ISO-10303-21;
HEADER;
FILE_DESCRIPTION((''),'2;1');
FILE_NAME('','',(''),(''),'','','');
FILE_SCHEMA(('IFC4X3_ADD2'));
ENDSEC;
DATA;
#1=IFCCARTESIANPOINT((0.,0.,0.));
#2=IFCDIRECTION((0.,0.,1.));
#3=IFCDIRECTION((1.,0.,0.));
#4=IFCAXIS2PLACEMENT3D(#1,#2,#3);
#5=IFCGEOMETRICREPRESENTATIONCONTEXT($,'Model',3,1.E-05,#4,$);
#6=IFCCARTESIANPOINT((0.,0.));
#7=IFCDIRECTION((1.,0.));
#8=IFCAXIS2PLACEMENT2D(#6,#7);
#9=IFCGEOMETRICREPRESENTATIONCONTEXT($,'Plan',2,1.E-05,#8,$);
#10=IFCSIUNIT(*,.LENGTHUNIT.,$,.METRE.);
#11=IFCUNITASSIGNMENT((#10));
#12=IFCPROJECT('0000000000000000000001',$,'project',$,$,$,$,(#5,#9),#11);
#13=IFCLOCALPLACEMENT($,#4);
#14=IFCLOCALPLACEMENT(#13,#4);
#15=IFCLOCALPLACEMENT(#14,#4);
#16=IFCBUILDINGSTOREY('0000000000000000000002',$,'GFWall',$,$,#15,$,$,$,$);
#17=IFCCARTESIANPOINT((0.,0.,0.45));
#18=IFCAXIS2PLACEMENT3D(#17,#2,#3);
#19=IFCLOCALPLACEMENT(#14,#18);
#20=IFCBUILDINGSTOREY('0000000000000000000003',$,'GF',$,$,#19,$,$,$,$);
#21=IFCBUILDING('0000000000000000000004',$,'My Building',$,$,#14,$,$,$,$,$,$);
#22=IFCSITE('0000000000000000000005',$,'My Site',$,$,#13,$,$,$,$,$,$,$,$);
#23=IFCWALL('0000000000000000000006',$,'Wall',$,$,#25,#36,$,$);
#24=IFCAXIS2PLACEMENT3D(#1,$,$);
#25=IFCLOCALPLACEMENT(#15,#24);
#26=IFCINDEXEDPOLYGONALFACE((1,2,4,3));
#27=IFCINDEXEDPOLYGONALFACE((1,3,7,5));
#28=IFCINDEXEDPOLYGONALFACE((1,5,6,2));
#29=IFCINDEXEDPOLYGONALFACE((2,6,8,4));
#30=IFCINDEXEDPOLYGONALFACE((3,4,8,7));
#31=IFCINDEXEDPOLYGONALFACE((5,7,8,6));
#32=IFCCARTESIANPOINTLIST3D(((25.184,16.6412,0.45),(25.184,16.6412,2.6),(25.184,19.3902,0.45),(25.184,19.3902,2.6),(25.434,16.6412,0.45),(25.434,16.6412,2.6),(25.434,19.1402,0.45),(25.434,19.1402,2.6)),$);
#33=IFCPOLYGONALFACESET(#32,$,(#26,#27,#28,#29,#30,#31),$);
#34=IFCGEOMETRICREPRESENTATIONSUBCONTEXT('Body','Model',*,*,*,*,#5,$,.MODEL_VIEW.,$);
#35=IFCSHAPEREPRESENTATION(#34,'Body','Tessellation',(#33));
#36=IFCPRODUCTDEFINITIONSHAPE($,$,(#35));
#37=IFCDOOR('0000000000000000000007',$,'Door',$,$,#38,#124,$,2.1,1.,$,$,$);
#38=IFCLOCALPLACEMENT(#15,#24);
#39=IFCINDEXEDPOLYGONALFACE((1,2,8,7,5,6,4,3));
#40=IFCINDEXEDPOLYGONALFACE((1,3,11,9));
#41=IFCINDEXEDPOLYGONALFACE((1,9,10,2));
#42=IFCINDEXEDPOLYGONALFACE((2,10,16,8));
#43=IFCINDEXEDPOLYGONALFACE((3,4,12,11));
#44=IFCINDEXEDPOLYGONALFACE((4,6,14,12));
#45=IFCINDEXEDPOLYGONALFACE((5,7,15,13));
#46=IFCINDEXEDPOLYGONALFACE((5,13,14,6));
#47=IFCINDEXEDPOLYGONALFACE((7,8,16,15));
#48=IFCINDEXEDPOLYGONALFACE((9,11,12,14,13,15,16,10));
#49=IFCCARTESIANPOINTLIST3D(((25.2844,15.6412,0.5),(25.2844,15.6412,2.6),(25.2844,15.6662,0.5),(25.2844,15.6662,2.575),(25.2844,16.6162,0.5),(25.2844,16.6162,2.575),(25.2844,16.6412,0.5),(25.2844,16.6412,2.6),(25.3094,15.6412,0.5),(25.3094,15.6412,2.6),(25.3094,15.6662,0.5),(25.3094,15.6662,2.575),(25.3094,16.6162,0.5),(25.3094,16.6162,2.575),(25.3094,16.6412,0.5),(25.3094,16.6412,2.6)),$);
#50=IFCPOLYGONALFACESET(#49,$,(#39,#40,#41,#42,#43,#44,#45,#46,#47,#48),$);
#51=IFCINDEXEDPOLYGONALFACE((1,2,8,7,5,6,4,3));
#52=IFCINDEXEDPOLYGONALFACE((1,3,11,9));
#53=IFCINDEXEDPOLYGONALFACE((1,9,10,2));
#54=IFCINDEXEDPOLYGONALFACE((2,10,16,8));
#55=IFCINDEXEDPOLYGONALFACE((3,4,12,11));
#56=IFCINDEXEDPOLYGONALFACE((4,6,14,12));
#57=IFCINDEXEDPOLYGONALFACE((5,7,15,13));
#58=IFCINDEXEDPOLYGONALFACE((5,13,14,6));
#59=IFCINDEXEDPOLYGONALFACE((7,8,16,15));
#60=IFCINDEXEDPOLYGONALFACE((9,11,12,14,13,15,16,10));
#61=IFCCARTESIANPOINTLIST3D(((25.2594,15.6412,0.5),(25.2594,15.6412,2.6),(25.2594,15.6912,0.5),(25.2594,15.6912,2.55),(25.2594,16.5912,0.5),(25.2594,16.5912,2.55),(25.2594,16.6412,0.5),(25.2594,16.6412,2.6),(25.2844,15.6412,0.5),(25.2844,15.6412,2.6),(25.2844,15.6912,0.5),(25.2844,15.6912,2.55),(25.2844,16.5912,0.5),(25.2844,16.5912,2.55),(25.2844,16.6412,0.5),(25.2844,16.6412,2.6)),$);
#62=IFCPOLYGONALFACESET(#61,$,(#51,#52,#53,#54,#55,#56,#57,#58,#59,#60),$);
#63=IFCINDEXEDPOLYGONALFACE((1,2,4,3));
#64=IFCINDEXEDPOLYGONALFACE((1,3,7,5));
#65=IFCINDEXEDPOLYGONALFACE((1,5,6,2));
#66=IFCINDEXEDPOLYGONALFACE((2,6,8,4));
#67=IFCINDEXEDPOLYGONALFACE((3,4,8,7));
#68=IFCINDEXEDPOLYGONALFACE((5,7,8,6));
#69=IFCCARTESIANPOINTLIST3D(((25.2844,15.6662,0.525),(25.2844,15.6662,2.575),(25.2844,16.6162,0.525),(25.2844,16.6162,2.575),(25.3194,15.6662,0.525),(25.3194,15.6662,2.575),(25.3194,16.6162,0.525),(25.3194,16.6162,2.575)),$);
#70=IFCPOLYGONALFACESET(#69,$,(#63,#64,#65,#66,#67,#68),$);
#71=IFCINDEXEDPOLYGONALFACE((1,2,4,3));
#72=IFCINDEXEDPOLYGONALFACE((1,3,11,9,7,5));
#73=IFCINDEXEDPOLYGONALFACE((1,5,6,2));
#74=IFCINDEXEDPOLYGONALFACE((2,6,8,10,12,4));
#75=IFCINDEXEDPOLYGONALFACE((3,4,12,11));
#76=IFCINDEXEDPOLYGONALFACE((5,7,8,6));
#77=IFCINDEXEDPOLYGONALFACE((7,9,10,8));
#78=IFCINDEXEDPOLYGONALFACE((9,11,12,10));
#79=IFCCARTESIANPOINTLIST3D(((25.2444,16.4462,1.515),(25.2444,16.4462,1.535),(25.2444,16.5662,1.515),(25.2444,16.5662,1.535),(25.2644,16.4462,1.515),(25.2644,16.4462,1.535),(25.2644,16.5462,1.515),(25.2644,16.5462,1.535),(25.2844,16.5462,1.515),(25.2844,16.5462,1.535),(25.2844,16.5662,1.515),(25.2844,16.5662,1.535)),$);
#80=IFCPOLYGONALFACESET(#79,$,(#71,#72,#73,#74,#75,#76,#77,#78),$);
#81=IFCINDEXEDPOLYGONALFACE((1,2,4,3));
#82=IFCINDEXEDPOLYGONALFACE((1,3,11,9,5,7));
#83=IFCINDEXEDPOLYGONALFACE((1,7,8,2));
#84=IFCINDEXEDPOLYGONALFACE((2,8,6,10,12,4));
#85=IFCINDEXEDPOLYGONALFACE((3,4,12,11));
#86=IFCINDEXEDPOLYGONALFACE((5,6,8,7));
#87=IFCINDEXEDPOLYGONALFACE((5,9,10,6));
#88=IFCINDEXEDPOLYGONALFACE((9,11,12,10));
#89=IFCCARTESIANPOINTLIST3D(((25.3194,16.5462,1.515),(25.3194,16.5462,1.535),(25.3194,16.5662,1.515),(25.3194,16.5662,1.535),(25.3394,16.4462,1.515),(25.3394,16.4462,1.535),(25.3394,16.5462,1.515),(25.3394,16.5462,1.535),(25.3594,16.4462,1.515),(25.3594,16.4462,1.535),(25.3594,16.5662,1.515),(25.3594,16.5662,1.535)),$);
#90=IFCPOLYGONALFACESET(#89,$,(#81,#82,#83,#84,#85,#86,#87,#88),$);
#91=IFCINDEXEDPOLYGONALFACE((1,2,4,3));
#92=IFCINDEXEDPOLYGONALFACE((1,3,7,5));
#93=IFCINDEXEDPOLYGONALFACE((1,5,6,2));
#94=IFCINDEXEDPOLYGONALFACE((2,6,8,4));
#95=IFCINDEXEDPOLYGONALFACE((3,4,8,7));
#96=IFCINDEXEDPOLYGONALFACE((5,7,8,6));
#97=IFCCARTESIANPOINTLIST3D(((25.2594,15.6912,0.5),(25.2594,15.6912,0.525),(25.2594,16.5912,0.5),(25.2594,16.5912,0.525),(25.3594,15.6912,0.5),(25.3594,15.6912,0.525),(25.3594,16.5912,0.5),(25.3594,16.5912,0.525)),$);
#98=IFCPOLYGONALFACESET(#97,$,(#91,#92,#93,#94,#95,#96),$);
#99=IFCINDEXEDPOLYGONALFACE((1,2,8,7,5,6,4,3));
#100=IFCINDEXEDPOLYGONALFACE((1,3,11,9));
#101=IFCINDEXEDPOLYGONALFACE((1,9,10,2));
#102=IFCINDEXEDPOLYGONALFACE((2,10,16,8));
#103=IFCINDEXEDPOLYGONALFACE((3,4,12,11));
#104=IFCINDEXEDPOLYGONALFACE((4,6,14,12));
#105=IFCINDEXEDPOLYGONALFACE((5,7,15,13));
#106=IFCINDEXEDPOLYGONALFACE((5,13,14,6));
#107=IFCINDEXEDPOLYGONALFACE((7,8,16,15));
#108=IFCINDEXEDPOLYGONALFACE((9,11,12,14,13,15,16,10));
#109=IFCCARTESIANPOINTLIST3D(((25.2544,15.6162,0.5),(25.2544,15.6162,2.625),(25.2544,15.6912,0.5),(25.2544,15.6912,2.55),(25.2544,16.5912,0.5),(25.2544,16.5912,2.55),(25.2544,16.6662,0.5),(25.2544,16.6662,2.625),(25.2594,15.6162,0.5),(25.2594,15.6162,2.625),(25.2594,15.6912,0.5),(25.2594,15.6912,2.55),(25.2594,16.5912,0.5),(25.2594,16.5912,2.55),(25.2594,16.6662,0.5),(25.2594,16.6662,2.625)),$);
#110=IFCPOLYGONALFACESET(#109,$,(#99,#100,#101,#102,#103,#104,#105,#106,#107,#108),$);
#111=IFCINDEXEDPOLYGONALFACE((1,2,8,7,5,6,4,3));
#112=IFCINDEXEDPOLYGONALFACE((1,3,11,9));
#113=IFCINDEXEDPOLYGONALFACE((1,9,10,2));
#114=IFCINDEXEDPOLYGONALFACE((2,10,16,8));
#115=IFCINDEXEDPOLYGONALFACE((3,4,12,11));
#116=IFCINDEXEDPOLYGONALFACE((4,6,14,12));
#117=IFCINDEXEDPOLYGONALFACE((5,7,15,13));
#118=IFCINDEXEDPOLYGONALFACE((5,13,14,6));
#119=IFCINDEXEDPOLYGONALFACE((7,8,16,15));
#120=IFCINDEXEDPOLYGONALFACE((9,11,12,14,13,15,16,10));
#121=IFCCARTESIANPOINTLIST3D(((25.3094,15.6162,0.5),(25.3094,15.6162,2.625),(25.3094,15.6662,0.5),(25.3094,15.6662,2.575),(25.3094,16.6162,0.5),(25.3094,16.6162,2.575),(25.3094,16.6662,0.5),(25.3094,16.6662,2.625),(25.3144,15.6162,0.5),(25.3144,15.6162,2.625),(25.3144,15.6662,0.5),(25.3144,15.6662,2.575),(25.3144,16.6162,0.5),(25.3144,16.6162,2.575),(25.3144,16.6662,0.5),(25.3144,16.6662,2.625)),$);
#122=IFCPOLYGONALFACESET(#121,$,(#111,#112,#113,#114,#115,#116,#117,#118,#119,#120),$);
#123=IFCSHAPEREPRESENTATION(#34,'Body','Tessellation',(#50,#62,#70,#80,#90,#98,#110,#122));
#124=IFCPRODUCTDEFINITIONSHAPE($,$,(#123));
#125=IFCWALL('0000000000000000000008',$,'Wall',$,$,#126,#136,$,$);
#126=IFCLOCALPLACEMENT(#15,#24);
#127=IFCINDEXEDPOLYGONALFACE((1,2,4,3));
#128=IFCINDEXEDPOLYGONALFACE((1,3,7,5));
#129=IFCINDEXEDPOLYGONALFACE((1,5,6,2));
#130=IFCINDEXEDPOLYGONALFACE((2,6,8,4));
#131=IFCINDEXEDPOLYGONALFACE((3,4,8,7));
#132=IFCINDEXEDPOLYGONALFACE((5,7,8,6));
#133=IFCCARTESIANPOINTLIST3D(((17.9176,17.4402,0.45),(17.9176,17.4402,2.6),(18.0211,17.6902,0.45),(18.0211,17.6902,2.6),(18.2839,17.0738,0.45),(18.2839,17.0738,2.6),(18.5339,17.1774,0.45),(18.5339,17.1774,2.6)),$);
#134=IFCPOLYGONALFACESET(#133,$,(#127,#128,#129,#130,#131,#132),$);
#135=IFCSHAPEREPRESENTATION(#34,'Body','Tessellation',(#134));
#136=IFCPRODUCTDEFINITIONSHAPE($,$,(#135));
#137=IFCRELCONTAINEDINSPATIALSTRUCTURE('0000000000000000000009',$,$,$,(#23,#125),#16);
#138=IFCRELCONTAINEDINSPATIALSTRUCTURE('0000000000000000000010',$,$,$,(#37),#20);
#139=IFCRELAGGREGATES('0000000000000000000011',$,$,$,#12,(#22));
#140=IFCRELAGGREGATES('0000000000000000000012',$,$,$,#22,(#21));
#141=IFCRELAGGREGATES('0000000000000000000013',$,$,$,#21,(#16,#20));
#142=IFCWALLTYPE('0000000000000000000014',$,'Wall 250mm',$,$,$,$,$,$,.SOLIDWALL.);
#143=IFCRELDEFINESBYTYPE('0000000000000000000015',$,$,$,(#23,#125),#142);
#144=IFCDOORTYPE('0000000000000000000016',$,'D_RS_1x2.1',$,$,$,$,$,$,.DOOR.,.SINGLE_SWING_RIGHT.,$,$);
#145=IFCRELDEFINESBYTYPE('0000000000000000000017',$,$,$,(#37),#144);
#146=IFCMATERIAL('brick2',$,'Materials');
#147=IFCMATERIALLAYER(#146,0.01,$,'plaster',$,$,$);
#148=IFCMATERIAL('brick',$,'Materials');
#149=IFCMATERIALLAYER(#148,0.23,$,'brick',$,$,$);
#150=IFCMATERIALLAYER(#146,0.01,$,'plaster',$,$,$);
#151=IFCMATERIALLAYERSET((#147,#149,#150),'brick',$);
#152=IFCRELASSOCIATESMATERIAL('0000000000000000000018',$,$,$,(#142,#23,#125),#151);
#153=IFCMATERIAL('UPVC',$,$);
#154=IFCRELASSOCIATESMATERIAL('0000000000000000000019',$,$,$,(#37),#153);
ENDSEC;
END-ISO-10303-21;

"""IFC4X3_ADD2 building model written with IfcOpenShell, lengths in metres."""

from ifc_helpers import new_model, entity, si_unit, frame, origin_with_axes, origin_2d_with_axis, place, context, subcontext, project, spatial, line, indexed_curve, outline, extrude, shape, source, transform, mapped, material, layer, layer_set, layer_usage, type_object, type_shapes, element, fill, save


model = new_model("IFC4X3_ADD2")

# Units and contexts
model_context = context("Model", 3, precision=1e-05, world=origin_with_axes())
plan_context = context("Plan", 2, precision=1e-05, world=origin_2d_with_axis())
body_context_1 = subcontext(model_context, "Body", "Model", "MODEL_VIEW")
body_context_2 = subcontext(plan_context, "Body", "Plan", "PLAN_VIEW")
ifc_project = project(units=[si_unit("LENGTHUNIT", "METRE")], contexts=[model_context, plan_context])

# Site, building, storey
site_placement = place(None, origin_with_axes())
site = spatial("IfcSite", under=ifc_project, at=site_placement, Name="My Site")
building_placement = place(site_placement, origin_with_axes())
building = spatial("IfcBuilding", under=site, at=building_placement, Name="My Building")
storey_1_placement = place(building_placement, origin_with_axes())
storey_1 = spatial("IfcBuildingStorey", under=building, at=storey_1_placement, Name="GFWall")

# Shared definitions
ifc_material_1 = material(Name="brick2", Category="Materials")
ifc_layer_1 = layer(ifc_material_1, 0.01, Name="plaster")
ifc_material_2 = material(Name="brick", Category="Materials")
ifc_layer_2 = layer(ifc_material_2, 0.23, Name="brick")
ifc_layer_3 = layer(ifc_material_1, 0.01, Name="plaster")
ifc_layer_set_1 = layer_set([ifc_layer_1, ifc_layer_2, ifc_layer_3], Name="brick")
wall_type_1 = type_object("IfcWallType", Name="Wall 250mm", PredefinedType="SOLIDWALL", material=ifc_layer_set_1)

# Shared definitions
storey_2_placement = place(building_placement, frame((0.0, 0.0, 0.45), z_axis=(0.0, 0.0, 1.0), x_axis=(1.0, 0.0, 0.0)))
storey_2 = spatial("IfcBuildingStorey", under=building, at=storey_2_placement, Name="GF")

# Shared definitions
ifc_material_3 = material(Name="UPVC")

# Wall, opening, door
ifc_layer_usage_1 = layer_usage(ifc_layer_set_1, "AXIS2", "POSITIVE", 0.0)
wall_1_placement = place(storey_1_placement, frame((25.434, 15.6412, 0.45), z_axis=(0.0, 0.0, 1.0), x_axis=(0.000001, 1.0, 0.0)))
wall_1 = element("IfcWall", 1, at=wall_1_placement, inside=storey_1, type_object=wall_type_1, material=ifc_layer_usage_1, Name="Wall", context=body_context_1, shape_type="SweptSolid", body=[
    extrude(outline(indexed_curve([(0.0, 0.0), (0.0, 0.25), (3.749, 0.25), (3.499, 0.0)], segments=[line(1, 2, 3, 4, 1)])), origin_with_axes(), (0.0, 0.0, 1.0), 2.15),
])
shared_shape_1 = source(origin_with_axes(), body_context_1, "Body", "SweptSolid", [
    extrude(outline(indexed_curve([(0.0, 2.1), (1.0, 2.1), (1.0, -0.05), (0.0, -0.05), (0.0, 2.1)])), frame((0.0, -0.6, 0.0), z_axis=(0.0, -1.0, 0.0), x_axis=(1.0, 0.0, 0.0)), (0.0, 0.0, -1.0), 1.2),
])
opening_1_placement = place(wall_1_placement, frame((1.0, 0.1746, 0.05), z_axis=(0.0, 0.0, 1.0), x_axis=(-1.0, 0.0, 0.0)))
opening_1 = element("IfcOpeningElement", 2, at=opening_1_placement, cuts=wall_1, PredefinedType="OPENING", context=body_context_1, shape_type="MappedRepresentation", body=[
    mapped(shared_shape_1, transform((0.0, 0.0, 0.0), x_axis=(1.0, 0.0, 0.0), y_axis=(0.0, 1.0, 0.0), z_axis=(0.0, 0.0, 1.0), scale=1.0)),
])
door_type_1 = type_object("IfcDoorType", Name="D_RS_1x2.1", OperationType="SINGLE_SWING_RIGHT", PredefinedType="DOOR")
shared_shape_2 = source(origin_with_axes(), body_context_1, "Body", "SweptSolid", [
    extrude(outline(indexed_curve([(0.0, 0.0), (0.0, 2.1), (1.0, 2.1), (1.0, 0.0), (0.975, 0.0), (0.975, 2.075), (0.025, 2.075), (0.025, 0.0)], segments=[line(1, 2, 3, 4, 5, 6, 7, 8, 1)])), frame((0.0, 0.025, 0.0), z_axis=(0.0, -1.0, 0.0), x_axis=(1.0, 0.0, 0.0)), (0.0, 0.0, -1.0), 0.025),
    extrude(outline(indexed_curve([(0.0, 0.0), (0.0, 2.1), (1.0, 2.1), (1.0, 0.0), (0.95, 0.0), (0.95, 2.05), (0.05, 2.05), (0.05, 0.0)], segments=[line(1, 2, 3, 4, 5, 6, 7, 8, 1)])), frame((0.0, 0.0, 0.0), z_axis=(0.0, -1.0, 0.0), x_axis=(1.0, 0.0, 0.0)), (0.0, 0.0, -1.0), 0.025),
    extrude(outline(indexed_curve([(0.0, 0.0), (0.95, 0.0), (0.95, 0.035), (0.0, 0.035)], segments=[line(1, 2, 3, 4, 1)])), frame((0.025, 0.025, 0.025), z_axis=(0.0, 0.0, 1.0), x_axis=(1.0, 0.0, 0.0)), (0.0, 0.0, 1.0), 2.05),
    extrude(outline(indexed_curve([(0.0, 0.0), (0.0, -0.04), (0.12, -0.04), (0.12, -0.02), (0.02, -0.02), (0.02, 0.0)], segments=[line(1, 2, 3, 4, 5, 6, 1)])), frame((0.075, 0.025, 1.015), z_axis=(0.0, 0.0, 1.0), x_axis=(1.0, 0.0, 0.0)), (0.0, 0.0, 1.0), 0.02),
    extrude(outline(indexed_curve([(0.0, 0.0), (0.0, 0.04), (0.12, 0.04), (0.12, 0.02), (0.02, 0.02), (0.02, 0.0)], segments=[line(1, 2, 3, 4, 5, 6, 1)])), frame((0.075, 0.06, 1.015), z_axis=(0.0, 0.0, 1.0), x_axis=(1.0, 0.0, 0.0)), (0.0, 0.0, 1.0), 0.02),
    extrude(outline(indexed_curve([(0.0, 0.0), (0.9, 0.0), (0.9, 0.1), (0.0, 0.1)], segments=[line(1, 2, 3, 4, 1)])), frame((0.05, 0.0, 0.0), z_axis=(0.0, 0.0, 1.0), x_axis=(1.0, 0.0, 0.0)), (0.0, 0.0, 1.0), 0.025),
    extrude(outline(indexed_curve([(0.0, 0.0), (0.0, 2.125), (1.05, 2.125), (1.05, 0.0), (0.975, 0.0), (0.975, 2.05), (0.075, 2.05), (0.075, 0.0)], segments=[line(1, 2, 3, 4, 5, 6, 7, 8, 1)])), frame((-0.025, -0.005, 0.0), z_axis=(0.0, -1.0, 0.0), x_axis=(1.0, 0.0, 0.0)), (0.0, 0.0, -1.0), 0.005),
    extrude(outline(indexed_curve([(0.0, 0.0), (0.0, 2.125), (1.05, 2.125), (1.05, 0.0), (1.0, 0.0), (1.0, 2.075), (0.05, 2.075), (0.05, 0.0)], segments=[line(1, 2, 3, 4, 5, 6, 7, 8, 1)])), frame((-0.025, 0.05, 0.0), z_axis=(0.0, -1.0, 0.0), x_axis=(1.0, 0.0, 0.0)), (0.0, 0.0, -1.0), 0.005),
])
shared_shape_3 = source(origin_with_axes(), body_context_2, "Body", "Curve2D", [
    entity("IfcIndexedPolyCurve", entity("IfcCartesianPointList2D", [[0.0, 0.0], [0.0, 0.05], [0.025, 0.05], [0.025, 0.025], [0.05, 0.025], [0.05, 0.0]]), [entity("IfcLineIndex", [1, 2, 3, 4, 5, 6, 1])]),
    entity("IfcIndexedPolyCurve", entity("IfcCartesianPointList2D", [[1.0, 0.0], [1.0, 0.05], [0.975, 0.05], [0.975, 0.025], [0.95, 0.025], [0.95, 0.0]]), [entity("IfcLineIndex", [1, 2, 3, 4, 5, 6, 1])]),
    entity("IfcTrimmedCurve", entity("IfcEllipse", entity("IfcAxis2Placement2D", entity("IfcCartesianPoint", [0.94, 0.05]), entity("IfcDirection", [1.0, 0.0])), 0.915, 0.95), [entity("IfcCartesianPoint", [0.94, 1.0])], [entity("IfcCartesianPoint", [0.025, 0.05])], True, "CARTESIAN"),
    entity("IfcIndexedPolyCurve", entity("IfcCartesianPointList2D", [[0.975, 0.05], [0.94, 0.05], [0.94, 1.0], [0.975, 1.0]]), [entity("IfcLineIndex", [1, 2, 3, 4, 1])]),
])
type_shapes(door_type_1, [shared_shape_2, shared_shape_3])
door_1_placement = place(opening_1_placement, origin_with_axes())
door_1 = element("IfcDoor", 3, at=door_1_placement, inside=storey_2, type_object=door_type_1, material=ifc_material_3, Name="Door", OverallHeight=2.1, OverallWidth=1.0, shapes=[
    shape(body_context_1, "Body", "MappedRepresentation", [mapped(shared_shape_2, transform((0.0, 0.0, 0.0), x_axis=(1.0, 0.0, 0.0), y_axis=(0.0, 1.0, 0.0), z_axis=(0.0, 0.0, 1.0), scale=1.0))]),
    shape(body_context_2, "Body", "MappedRepresentation", [mapped(shared_shape_3, transform((0.0, 0.0, 0.0), x_axis=(1.0, 0.0, 0.0), y_axis=(0.0, 1.0, 0.0), z_axis=(0.0, 0.0, 1.0), scale=1.0))]),
])
fill(opening_1, door_1)

# Wall
ifc_layer_usage_2 = layer_usage(ifc_layer_set_1, "AXIS2", "NEGATIVE", 0.0)
wall_2_placement = place(storey_1_placement, frame((18.2839, 17.0738, 0.45), z_axis=(0.0, 0.0, 1.0), x_axis=(-0.707107, 0.707107, 0.0)))
element("IfcWall", 4, at=wall_2_placement, inside=storey_1, type_object=wall_type_1, material=ifc_layer_usage_2, Name="Wall", context=body_context_1, shape_type="SweptSolid", body=[
    extrude(outline(indexed_curve([(-0.1036, -0.25), (0.0, 0.0), (0.5181, 0.0), (0.6217, -0.25)], segments=[line(1, 2, 3, 4, 1)])), origin_with_axes(), (0.0, 0.0, 1.0), 2.15),
])

save(model, "model.ifc")
